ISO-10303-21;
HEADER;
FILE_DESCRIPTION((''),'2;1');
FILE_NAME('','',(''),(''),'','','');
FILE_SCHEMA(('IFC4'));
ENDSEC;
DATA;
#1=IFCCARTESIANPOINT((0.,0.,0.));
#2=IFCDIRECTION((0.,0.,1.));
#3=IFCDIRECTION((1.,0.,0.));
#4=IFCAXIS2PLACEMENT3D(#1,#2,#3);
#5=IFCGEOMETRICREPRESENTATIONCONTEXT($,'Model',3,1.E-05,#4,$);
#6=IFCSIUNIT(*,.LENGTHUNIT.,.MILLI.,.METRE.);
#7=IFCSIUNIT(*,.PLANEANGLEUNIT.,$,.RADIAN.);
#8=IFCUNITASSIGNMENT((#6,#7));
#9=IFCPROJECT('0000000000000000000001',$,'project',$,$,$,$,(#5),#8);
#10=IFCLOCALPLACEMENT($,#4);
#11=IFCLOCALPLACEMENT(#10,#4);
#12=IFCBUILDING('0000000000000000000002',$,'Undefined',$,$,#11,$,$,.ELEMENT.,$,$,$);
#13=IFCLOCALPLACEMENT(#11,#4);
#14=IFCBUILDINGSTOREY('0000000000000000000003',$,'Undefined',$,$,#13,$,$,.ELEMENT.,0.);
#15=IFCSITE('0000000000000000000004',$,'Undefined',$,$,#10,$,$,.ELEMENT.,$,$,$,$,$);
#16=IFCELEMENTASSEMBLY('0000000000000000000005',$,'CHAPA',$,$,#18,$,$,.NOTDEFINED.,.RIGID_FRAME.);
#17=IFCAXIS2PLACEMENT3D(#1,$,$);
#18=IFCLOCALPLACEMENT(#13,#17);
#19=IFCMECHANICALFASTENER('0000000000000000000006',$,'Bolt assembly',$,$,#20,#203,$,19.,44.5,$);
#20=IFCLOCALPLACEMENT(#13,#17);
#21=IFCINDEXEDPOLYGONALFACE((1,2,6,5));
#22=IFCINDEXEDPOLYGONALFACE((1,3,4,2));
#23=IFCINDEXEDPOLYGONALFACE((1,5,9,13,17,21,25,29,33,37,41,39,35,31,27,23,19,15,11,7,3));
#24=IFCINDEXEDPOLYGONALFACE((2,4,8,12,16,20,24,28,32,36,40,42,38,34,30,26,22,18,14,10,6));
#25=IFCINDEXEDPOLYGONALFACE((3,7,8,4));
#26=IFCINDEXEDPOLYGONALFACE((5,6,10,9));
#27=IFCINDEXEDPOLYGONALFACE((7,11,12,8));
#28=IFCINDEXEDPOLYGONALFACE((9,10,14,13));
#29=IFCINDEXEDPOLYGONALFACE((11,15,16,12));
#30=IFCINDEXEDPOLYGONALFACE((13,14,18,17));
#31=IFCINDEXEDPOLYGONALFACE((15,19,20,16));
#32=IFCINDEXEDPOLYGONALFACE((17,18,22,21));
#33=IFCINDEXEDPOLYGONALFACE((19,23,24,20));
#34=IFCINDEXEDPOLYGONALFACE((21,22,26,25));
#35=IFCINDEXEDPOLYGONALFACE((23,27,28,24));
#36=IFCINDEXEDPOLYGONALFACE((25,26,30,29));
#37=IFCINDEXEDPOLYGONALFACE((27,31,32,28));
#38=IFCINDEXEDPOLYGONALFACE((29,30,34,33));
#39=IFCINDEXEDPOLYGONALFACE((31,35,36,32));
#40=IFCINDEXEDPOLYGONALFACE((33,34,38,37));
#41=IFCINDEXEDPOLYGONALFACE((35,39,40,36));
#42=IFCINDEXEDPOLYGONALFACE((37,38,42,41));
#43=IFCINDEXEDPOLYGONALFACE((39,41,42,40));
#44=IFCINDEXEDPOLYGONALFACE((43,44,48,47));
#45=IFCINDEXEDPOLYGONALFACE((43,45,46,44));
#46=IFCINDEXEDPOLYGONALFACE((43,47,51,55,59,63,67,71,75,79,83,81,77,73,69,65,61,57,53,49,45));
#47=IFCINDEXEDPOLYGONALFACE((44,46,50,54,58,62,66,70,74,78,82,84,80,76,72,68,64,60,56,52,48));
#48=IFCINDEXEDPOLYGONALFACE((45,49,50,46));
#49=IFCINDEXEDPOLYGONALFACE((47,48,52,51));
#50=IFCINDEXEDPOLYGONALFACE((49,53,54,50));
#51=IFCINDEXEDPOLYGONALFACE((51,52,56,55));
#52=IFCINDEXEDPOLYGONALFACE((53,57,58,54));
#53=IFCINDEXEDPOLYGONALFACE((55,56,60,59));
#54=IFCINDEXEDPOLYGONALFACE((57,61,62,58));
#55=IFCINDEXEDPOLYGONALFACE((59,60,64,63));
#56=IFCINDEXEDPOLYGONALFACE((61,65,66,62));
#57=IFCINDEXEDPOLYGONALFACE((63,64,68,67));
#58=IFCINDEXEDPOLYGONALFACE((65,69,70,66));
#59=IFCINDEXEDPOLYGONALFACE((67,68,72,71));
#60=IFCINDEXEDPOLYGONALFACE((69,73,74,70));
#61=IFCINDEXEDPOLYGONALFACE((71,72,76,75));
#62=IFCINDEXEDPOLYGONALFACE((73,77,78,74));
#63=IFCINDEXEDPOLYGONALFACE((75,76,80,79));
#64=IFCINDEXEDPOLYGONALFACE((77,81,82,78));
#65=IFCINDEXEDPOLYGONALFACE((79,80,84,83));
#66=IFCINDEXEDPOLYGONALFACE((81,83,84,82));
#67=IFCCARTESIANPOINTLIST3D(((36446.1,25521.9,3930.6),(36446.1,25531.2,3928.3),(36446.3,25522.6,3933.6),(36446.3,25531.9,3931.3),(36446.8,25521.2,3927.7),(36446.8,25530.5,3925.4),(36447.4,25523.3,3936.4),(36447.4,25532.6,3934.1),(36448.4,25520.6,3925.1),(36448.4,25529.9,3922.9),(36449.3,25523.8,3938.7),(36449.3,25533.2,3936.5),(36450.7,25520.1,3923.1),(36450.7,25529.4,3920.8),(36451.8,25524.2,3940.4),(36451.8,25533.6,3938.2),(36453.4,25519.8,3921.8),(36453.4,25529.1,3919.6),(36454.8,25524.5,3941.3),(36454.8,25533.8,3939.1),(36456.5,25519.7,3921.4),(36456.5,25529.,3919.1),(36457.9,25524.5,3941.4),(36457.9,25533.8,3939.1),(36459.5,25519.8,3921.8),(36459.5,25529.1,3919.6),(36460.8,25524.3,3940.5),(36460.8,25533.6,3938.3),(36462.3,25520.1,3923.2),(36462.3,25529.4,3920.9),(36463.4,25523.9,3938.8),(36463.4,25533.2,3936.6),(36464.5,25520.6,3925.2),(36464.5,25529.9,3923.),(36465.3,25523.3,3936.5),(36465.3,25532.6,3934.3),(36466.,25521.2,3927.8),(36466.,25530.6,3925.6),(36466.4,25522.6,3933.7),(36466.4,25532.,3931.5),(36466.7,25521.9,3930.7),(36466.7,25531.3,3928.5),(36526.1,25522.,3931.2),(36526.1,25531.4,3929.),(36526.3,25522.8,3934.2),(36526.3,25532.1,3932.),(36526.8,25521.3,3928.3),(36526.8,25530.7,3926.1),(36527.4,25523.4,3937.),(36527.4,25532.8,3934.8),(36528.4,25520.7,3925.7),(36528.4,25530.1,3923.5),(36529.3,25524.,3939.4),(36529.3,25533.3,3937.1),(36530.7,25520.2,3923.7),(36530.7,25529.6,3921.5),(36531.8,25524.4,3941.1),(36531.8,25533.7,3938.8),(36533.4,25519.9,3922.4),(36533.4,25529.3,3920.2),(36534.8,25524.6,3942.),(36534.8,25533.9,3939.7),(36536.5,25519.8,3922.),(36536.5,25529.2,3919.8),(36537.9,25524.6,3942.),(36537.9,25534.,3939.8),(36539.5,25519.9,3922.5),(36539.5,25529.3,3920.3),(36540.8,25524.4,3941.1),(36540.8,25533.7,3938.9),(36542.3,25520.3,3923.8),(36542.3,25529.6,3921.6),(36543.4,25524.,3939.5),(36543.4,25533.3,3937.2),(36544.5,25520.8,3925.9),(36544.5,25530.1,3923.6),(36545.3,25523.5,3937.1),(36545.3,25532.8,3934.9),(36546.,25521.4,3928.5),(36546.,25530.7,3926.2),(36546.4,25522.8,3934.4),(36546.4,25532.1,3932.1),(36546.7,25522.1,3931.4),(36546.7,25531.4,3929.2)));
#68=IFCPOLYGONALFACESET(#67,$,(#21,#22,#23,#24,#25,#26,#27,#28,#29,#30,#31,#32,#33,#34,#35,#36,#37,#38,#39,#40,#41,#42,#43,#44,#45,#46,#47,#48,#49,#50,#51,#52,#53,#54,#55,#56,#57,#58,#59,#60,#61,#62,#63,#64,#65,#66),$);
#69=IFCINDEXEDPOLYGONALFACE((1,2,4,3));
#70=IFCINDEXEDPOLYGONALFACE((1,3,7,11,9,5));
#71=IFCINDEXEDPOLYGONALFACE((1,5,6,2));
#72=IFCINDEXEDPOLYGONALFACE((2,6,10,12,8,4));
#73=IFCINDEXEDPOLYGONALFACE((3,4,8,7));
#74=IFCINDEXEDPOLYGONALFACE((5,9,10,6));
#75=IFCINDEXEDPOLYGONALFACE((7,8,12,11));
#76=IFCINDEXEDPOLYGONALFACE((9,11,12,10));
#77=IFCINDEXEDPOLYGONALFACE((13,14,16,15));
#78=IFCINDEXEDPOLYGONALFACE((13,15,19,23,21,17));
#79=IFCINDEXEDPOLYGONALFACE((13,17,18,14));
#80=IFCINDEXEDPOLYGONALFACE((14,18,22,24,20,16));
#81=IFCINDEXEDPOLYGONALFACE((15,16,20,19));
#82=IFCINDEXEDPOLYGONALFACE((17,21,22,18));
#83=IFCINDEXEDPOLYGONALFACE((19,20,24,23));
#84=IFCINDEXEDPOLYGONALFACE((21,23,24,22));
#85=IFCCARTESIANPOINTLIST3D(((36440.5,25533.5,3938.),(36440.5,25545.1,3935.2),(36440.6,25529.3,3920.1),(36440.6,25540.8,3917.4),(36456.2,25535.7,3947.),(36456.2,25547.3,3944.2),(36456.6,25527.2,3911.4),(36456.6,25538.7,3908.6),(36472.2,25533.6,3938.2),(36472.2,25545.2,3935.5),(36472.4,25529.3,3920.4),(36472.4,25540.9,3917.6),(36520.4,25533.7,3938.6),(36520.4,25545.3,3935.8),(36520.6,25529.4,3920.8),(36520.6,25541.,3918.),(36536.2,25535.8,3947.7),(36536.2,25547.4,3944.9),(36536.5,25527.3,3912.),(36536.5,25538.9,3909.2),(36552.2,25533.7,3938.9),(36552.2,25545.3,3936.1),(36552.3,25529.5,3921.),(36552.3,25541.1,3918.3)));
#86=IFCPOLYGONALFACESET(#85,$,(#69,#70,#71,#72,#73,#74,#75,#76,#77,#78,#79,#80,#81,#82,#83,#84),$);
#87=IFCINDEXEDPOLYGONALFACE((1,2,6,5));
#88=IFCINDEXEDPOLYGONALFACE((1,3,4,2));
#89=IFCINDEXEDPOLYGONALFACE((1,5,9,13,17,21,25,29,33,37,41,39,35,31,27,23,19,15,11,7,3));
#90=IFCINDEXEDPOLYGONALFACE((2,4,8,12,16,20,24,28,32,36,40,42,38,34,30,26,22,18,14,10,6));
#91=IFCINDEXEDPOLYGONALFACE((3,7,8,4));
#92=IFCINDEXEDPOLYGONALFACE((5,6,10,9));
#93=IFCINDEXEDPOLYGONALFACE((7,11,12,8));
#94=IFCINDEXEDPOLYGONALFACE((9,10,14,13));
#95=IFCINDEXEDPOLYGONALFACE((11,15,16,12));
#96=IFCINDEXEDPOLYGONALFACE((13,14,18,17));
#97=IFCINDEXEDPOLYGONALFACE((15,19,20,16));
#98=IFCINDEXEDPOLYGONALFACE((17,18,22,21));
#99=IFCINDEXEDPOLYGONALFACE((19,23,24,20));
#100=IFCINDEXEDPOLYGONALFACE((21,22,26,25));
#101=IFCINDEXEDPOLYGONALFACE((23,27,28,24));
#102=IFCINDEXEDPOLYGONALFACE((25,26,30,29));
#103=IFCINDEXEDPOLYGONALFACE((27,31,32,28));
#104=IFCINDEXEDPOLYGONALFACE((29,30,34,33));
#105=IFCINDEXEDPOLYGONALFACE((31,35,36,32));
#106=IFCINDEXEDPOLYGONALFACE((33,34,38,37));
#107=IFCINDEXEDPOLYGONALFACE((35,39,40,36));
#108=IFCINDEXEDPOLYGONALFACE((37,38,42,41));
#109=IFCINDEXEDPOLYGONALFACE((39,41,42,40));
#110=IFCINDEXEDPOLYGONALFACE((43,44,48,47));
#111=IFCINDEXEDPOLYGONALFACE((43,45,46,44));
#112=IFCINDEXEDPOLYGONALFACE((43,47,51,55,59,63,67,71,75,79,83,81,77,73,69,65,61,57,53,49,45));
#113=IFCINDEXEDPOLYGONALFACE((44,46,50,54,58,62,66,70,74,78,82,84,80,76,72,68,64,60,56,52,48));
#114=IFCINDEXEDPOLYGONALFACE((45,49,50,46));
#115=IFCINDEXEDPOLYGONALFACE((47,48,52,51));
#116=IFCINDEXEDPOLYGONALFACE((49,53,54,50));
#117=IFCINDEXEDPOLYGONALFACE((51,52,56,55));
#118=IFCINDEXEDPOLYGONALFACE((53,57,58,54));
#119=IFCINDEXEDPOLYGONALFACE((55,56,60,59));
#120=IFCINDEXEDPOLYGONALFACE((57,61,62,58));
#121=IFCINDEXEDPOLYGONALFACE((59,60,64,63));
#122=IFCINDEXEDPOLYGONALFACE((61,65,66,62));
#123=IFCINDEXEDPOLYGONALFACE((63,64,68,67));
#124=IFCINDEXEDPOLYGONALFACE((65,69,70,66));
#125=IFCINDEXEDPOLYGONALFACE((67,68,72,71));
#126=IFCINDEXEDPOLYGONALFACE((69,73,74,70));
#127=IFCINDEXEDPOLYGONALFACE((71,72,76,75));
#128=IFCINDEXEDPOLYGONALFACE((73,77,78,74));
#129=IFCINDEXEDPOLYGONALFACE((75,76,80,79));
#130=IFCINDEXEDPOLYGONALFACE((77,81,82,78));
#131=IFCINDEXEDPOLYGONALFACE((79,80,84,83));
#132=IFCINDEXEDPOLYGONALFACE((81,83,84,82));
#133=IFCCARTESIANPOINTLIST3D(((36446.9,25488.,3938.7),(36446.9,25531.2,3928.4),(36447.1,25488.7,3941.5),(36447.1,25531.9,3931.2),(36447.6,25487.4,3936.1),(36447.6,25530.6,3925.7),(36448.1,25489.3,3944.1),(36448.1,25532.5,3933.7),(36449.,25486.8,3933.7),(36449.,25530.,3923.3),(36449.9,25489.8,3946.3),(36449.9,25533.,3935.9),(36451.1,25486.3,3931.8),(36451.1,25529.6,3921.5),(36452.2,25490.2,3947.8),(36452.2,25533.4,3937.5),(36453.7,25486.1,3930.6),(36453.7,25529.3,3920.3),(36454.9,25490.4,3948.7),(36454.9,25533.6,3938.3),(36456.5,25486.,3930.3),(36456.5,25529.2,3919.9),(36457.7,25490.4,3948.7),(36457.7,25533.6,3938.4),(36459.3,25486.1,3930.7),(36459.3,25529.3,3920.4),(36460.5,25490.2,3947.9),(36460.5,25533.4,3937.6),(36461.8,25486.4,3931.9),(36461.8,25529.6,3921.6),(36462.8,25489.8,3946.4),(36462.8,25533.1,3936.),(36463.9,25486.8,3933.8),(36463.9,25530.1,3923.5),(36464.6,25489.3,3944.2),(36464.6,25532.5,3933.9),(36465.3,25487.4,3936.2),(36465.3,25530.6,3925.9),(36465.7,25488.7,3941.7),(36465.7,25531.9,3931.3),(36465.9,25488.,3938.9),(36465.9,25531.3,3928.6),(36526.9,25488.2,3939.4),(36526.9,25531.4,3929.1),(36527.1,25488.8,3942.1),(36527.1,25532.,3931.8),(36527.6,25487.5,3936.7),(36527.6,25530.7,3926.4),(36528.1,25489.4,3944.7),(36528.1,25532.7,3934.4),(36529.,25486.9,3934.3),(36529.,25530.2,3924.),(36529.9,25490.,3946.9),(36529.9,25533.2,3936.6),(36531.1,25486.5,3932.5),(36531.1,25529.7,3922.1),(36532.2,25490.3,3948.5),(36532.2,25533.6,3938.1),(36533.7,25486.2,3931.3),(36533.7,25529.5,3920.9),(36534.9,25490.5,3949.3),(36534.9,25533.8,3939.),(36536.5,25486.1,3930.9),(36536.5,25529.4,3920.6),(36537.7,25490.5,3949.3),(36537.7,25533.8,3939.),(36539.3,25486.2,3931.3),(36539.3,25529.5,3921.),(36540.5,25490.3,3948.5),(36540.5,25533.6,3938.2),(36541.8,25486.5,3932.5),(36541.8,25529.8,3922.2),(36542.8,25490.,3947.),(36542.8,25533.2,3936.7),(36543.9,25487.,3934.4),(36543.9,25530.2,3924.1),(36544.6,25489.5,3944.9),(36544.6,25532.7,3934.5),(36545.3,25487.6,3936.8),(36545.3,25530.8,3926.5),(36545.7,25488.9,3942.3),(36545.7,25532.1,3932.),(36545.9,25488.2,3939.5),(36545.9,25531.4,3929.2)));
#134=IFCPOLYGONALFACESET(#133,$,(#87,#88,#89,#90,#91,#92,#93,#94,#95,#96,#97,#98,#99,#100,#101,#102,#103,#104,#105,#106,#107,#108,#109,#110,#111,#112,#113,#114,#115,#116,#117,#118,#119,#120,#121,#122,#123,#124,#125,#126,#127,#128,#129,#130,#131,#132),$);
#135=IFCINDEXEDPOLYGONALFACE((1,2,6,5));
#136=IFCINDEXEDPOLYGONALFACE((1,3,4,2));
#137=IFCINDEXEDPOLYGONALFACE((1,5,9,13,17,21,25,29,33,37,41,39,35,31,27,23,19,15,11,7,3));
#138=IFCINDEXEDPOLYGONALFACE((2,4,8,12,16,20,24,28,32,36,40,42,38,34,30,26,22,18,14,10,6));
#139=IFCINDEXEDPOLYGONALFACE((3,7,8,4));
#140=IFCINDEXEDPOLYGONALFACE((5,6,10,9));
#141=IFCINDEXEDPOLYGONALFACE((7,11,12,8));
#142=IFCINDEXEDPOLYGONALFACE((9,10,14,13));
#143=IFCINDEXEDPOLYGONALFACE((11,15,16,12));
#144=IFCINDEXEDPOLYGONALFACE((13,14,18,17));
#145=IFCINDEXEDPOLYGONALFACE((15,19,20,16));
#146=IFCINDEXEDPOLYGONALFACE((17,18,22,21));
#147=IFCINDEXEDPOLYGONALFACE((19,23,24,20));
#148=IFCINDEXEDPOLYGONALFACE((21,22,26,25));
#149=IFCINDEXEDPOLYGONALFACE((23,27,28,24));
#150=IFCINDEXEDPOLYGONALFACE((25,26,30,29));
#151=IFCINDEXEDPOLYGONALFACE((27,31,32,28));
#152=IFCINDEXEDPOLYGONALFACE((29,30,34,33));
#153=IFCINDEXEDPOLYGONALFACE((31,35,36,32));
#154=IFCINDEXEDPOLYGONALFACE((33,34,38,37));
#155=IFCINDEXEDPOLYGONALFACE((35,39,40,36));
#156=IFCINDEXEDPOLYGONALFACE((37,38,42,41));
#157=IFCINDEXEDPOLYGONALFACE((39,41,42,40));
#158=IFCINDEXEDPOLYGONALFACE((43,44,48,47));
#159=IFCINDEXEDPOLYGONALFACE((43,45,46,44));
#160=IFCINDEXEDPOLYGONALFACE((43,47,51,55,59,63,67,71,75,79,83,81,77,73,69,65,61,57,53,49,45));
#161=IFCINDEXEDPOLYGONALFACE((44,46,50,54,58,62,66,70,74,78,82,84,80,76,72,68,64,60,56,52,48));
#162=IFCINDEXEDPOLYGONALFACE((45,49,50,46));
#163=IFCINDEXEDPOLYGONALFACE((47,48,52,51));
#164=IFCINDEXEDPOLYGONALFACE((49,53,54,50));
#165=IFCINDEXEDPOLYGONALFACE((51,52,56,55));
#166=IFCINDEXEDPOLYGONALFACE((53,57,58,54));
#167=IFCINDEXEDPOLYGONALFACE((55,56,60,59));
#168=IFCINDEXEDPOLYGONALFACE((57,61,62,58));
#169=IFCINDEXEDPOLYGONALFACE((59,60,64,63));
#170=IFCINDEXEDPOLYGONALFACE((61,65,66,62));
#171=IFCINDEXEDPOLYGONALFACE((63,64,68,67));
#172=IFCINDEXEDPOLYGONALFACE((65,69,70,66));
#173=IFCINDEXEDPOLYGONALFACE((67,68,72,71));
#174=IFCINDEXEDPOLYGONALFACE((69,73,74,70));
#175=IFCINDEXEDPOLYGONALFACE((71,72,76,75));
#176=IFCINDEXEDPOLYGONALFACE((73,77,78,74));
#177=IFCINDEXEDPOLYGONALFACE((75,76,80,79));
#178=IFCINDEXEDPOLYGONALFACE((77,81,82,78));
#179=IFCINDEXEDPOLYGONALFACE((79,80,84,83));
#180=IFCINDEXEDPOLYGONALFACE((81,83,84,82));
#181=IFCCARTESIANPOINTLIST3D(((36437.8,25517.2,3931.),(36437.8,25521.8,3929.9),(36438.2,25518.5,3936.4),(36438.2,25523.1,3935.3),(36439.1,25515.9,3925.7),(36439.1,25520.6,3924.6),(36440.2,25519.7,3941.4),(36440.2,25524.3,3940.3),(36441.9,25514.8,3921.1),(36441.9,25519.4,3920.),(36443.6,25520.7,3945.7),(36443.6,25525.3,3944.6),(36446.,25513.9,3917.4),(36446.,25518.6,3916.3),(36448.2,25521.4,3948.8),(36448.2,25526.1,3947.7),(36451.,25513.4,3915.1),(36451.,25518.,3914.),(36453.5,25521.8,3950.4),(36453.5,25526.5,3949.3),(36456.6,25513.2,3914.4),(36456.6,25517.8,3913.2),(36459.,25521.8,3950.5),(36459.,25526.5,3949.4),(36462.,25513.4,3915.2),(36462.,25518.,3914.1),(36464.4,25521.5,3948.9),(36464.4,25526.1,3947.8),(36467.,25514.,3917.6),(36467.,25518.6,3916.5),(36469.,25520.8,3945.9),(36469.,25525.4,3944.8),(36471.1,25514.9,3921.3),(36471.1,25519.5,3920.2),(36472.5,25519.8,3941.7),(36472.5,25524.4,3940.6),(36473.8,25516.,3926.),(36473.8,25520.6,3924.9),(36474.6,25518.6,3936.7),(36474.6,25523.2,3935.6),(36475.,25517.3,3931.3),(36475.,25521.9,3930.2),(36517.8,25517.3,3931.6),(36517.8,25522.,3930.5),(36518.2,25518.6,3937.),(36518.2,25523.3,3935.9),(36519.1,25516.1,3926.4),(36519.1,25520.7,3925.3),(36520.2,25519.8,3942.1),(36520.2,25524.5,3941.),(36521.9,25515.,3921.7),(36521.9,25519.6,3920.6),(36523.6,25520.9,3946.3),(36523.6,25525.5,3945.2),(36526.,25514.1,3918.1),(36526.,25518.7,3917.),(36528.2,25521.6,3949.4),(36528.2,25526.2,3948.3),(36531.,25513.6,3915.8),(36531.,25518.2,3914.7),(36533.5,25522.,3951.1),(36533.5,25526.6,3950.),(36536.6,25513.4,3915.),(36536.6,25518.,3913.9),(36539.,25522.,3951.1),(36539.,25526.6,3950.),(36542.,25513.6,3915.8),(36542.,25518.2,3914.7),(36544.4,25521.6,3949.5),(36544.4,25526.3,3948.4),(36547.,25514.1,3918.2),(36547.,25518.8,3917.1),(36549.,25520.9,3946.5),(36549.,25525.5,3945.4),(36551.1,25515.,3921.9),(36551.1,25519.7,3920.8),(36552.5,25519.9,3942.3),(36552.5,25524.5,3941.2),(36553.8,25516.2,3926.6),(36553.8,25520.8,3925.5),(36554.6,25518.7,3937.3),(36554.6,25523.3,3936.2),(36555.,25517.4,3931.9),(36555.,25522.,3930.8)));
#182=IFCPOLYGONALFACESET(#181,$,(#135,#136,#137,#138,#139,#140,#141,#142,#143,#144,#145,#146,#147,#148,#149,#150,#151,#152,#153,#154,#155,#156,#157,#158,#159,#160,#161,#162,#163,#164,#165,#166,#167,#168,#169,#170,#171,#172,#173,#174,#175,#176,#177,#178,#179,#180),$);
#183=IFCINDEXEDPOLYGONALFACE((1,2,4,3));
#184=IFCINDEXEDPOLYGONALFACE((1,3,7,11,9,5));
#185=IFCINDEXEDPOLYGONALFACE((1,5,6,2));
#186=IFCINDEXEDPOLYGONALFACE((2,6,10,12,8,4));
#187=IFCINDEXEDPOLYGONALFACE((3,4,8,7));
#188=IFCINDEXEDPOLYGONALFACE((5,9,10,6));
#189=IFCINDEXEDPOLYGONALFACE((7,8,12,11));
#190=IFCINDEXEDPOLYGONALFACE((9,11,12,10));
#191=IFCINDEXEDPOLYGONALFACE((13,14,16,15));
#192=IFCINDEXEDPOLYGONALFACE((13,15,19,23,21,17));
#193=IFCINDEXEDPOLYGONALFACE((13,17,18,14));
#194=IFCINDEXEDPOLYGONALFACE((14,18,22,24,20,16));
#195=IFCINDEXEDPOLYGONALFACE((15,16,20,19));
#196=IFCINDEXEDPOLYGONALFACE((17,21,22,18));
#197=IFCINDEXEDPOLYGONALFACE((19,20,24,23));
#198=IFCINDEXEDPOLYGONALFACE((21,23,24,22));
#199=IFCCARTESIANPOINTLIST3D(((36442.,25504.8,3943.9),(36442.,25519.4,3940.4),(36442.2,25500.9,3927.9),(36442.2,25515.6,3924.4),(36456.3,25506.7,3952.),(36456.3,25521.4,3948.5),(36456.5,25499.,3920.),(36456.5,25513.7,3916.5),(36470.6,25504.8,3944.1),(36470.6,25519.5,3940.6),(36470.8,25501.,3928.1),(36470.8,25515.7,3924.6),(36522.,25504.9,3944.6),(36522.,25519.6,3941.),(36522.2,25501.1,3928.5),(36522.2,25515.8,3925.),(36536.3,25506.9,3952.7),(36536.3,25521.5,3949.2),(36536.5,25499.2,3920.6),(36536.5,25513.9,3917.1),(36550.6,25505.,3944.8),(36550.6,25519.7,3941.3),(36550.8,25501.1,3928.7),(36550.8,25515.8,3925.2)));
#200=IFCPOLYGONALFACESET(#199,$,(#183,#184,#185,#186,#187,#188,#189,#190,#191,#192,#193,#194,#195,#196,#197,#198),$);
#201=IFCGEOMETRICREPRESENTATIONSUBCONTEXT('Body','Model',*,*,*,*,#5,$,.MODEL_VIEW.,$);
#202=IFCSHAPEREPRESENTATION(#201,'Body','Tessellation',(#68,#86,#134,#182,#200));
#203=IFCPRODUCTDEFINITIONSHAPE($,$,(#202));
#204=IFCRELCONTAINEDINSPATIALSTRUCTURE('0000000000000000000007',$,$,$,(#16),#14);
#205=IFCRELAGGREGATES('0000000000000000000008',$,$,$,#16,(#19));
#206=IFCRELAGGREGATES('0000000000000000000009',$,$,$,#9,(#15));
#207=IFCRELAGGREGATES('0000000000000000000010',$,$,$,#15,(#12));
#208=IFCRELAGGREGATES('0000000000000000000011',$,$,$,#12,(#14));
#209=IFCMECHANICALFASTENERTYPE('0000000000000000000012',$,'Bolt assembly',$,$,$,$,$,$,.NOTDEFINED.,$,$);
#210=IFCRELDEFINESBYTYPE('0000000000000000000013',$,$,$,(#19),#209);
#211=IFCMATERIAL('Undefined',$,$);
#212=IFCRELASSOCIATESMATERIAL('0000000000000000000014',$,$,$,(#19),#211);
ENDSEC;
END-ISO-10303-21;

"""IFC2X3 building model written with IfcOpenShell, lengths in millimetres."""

from ifc_helpers import new_model, si_unit, frame, origin_with_axes, origin_2d_with_axis, place, context, subcontext, project, spatial, polyline, circle, outline, extrude, source, transform, mapped, material, type_object, element, aggregate, save


model = new_model("IFC2X3")

# Units and contexts
model_context = context("Model", 3, precision=1e-05, world=origin_with_axes())
body_context = subcontext(model_context, "Body", "Model", "MODEL_VIEW")
ifc_project = project(units=[si_unit("LENGTHUNIT", "METRE", prefix="MILLI"), si_unit("PLANEANGLEUNIT", "RADIAN")], contexts=[model_context])

# Site, building, storey
site_placement = place(None, origin_with_axes())
site = spatial("IfcSite", under=ifc_project, at=site_placement, Name="Undefined", CompositionType="ELEMENT")
building_placement = place(site_placement, origin_with_axes())
building = spatial("IfcBuilding", under=site, at=building_placement, Name="Undefined", CompositionType="ELEMENT")
storey_placement = place(building_placement, origin_with_axes())
storey = spatial("IfcBuildingStorey", under=building, at=storey_placement, Name="Undefined", CompositionType="ELEMENT", Elevation=0.0)

# Element assembly
assembly_1_placement = place(storey_placement, origin_with_axes())
assembly_1 = element("IfcElementAssembly", 1, at=assembly_1_placement, inside=storey, Name="CHAPA", AssemblyPlace="NOTDEFINED", PredefinedType="RIGID_FRAME")

# Shared definitions
ifc_material_1 = material(Name="Undefined")
mechanical_fastener_type = type_object("IfcMechanicalFastenerType", Name="Bolt assembly")

# Mechanical fastener
shared_shape_1 = source(origin_with_axes(), body_context, "Body", "SweptSolid", [
    extrude(circle(Radius=10.3, at=origin_2d_with_axis()), frame((0.0, 0.0, 0.0), z_axis=(0.0, 1.0, 0.0), x_axis=(1.0, 0.0, 0.0)), (0.0, 0.0, 1.0), 9.6),
    extrude(outline(polyline([(18.3, 0.0), (9.2, 15.9), (-9.2, 15.9), (-18.3, 0.0), (-9.2, -15.9), (9.2, -15.9), (18.3, 0.0)])), frame((0.0, -11.9, 0.0), z_axis=(0.0, 1.0, 0.0), x_axis=(1.0, 0.0, 0.0)), (0.0, 0.0, 1.0), 11.9),
    extrude(circle(Radius=9.5, at=origin_2d_with_axis()), frame((0.0, 0.0, 0.0), z_axis=(0.0, 1.0, 0.0), x_axis=(1.0, 0.0, 0.0)), (0.0, 0.0, 1.0), 44.5),
    extrude(circle(Radius=18.7, at=origin_2d_with_axis()), frame((0.0, 9.5, 0.0), z_axis=(0.0, 1.0, 0.0), x_axis=(1.0, 0.0, 0.0)), (0.0, 0.0, 1.0), 4.8),
    extrude(outline(polyline([(16.5, 0.0), (8.2, 14.3), (-8.2, 14.3), (-16.5, 0.0), (-8.2, -14.3), (8.2, -14.3), (16.5, 0.0)])), frame((0.0, 14.3, 0.0), z_axis=(0.0, 1.0, 0.0), x_axis=(1.0, 0.0, 0.0)), (0.0, 0.0, 1.0), 15.1),
])
mechanical_fastener_1_placement = place(assembly_1_placement, frame((36496.4, 25531.5, 3929.5), z_axis=(-0.999966, -0.001919, -0.008026), x_axis=(0.008253, -0.23249, -0.972564)))
mechanical_fastener_1 = element("IfcMechanicalFastener", 2, at=mechanical_fastener_1_placement, type_object=mechanical_fastener_type, material=ifc_material_1, Name="Bolt assembly", NominalDiameter=19.0, NominalLength=44.5, context=body_context, shape_type="MappedRepresentation", body=[
    mapped(shared_shape_1, transform((0.0, 0.0, 40.0))),
    mapped(shared_shape_1, transform((0.0, 0.0, -40.0))),
])
aggregate(assembly_1, [mechanical_fastener_1])

save(model, "model.ifc")
